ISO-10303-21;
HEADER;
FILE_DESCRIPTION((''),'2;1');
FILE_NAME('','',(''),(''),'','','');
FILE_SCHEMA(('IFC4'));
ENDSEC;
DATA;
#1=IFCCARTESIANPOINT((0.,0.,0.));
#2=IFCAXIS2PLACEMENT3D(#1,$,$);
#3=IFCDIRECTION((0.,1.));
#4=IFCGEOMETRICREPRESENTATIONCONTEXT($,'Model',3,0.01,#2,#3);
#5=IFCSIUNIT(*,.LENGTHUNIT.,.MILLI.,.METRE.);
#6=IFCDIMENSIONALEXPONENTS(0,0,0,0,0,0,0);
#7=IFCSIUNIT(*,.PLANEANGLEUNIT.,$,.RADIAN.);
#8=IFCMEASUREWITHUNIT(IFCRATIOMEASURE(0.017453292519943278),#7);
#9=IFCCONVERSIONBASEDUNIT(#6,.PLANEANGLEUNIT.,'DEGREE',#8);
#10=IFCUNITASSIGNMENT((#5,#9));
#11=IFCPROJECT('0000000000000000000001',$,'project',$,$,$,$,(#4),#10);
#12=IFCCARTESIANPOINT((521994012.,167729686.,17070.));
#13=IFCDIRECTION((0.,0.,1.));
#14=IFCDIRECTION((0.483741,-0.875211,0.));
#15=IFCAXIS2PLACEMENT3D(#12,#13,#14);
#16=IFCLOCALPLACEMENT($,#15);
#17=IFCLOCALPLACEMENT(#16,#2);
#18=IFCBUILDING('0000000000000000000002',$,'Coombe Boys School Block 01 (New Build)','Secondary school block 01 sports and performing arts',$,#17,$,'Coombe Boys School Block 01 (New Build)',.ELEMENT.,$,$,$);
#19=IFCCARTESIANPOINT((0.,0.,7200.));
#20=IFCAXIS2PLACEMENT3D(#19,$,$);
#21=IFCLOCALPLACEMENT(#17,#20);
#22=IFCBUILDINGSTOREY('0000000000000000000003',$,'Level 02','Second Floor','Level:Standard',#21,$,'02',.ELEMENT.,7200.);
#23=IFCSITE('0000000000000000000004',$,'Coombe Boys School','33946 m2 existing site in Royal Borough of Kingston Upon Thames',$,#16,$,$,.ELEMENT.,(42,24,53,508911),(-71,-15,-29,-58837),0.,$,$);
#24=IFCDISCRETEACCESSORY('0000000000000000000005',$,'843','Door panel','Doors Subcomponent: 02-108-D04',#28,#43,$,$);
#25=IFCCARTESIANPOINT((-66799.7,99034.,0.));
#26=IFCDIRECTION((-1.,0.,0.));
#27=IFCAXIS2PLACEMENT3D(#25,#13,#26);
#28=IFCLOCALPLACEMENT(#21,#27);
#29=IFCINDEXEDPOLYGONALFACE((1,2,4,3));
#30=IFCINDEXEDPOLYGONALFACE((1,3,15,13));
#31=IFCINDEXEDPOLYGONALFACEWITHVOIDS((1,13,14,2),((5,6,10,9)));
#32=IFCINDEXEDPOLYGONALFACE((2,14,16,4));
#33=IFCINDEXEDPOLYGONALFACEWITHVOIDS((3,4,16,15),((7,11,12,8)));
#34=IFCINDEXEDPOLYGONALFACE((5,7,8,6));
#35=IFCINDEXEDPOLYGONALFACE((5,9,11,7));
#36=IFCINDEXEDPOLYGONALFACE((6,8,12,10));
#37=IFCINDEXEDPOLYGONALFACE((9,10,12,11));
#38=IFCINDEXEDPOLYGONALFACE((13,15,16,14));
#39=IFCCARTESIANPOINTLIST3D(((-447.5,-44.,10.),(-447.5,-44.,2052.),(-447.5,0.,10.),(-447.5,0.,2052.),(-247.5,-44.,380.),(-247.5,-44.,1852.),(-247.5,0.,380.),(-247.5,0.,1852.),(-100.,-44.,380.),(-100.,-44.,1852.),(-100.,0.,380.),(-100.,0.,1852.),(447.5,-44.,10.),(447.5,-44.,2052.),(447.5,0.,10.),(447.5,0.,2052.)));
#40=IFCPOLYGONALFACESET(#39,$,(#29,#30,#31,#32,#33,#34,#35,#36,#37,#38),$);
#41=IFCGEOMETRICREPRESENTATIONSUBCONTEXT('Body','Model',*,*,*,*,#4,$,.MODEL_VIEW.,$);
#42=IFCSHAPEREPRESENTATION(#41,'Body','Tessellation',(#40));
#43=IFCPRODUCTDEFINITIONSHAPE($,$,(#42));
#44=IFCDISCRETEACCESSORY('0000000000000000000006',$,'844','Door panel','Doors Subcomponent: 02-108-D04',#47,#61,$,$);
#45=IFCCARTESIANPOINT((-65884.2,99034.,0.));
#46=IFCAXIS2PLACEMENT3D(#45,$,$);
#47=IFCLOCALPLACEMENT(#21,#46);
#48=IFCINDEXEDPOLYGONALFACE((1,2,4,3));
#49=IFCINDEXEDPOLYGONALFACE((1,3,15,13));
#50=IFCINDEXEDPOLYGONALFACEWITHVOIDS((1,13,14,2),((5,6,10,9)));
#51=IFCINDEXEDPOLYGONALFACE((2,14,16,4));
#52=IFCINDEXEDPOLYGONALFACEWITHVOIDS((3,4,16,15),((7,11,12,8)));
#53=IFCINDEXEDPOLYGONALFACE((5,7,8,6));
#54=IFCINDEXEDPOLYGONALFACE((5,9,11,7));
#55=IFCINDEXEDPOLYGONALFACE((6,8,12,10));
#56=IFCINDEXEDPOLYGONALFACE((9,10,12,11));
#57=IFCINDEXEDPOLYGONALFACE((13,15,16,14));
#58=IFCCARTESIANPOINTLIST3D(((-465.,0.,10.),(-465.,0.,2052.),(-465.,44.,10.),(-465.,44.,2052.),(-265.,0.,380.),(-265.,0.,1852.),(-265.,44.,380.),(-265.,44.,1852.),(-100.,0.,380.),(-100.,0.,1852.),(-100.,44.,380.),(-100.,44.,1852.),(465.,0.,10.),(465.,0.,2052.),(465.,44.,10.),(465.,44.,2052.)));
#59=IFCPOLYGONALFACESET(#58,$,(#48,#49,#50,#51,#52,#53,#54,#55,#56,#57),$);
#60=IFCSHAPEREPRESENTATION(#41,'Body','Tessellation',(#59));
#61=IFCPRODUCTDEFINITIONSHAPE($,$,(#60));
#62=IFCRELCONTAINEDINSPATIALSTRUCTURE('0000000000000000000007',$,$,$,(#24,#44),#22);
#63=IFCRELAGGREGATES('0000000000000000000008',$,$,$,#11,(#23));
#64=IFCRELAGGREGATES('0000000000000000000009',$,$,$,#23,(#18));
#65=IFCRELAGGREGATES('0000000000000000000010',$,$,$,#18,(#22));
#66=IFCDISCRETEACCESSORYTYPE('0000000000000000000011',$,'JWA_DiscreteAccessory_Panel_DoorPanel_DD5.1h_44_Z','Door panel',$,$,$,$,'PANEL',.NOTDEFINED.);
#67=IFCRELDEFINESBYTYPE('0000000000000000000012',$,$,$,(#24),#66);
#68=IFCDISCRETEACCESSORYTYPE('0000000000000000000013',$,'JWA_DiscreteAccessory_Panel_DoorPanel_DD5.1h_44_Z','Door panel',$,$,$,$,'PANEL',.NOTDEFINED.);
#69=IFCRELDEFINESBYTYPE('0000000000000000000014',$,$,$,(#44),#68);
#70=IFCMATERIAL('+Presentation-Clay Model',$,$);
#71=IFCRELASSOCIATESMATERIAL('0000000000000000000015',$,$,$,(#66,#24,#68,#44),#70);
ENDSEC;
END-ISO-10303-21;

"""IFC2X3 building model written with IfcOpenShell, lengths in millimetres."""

from ifc_helpers import new_model, entity, si_unit, converted_unit, direction, frame, origin, place, context, subcontext, project, spatial, polyline, outline, extrude, source, transform, mapped, material, type_object, type_shapes, element, save


model = new_model("IFC2X3")

# Units and contexts
model_context = context("Model", 3, precision=0.01, world=origin(), true_north=direction((0.0, 1.0)))
body_context = subcontext(model_context, "Body", "Model", "MODEL_VIEW")
ifc_project = project(units=[si_unit("LENGTHUNIT", "METRE", prefix="MILLI"), converted_unit("PLANEANGLEUNIT", "DEGREE", entity("IfcRatioMeasure", 0.017453292519943278), si_unit("PLANEANGLEUNIT", "RADIAN"), dimensions=[0, 0, 0, 0, 0, 0, 0])], contexts=[model_context])

# Site, building, storey
site_placement = place(None, frame((521994012.0, 167729686.0, 17070.0), z_axis=(0.0, 0.0, 1.0), x_axis=(0.483741, -0.875211, 0.0)))
site = spatial("IfcSite", under=ifc_project, at=site_placement, Name="Coombe Boys School", Description="33946 m2 existing site in Royal Borough of Kingston Upon Thames", CompositionType="ELEMENT", RefLatitude=(42, 24, 53, 508911), RefLongitude=(-71, -15, -29, -58837), RefElevation=0.0)
building_placement = place(site_placement, origin())
building = spatial("IfcBuilding", under=site, at=building_placement, Name="Coombe Boys School Block 01 (New Build)", Description="Secondary school block 01 sports and performing arts", LongName="Coombe Boys School Block 01 (New Build)", CompositionType="ELEMENT")
storey_placement = place(building_placement, frame((0.0, 0.0, 7200.0)))
storey = spatial("IfcBuildingStorey", under=building, at=storey_placement, Name="Level 02", Description="Second Floor", ObjectType="Level:Standard", LongName="02", CompositionType="ELEMENT", Elevation=7200.0)

# Discrete accessories
ifc_material_1 = material(Name="+Presentation-Clay Model")
discrete_accessory_type_1 = type_object("IfcDiscreteAccessoryType", Name="JWA_DiscreteAccessory_Panel_DoorPanel_DD5.1h_44_Z", Description="Door panel", ElementType="PANEL", material=ifc_material_1)
shared_shape_1 = source(origin(), body_context, "Body", "SweptSolid", [
    extrude(outline(polyline([(-1021.0, -447.5), (1021.0, -447.5), (1021.0, 447.5), (-1021.0, 447.5), (-1021.0, -447.5)]), holes=[polyline([(-821.0, 100.0), (-821.0, 247.5), (651.0, 247.5), (651.0, 100.0), (-821.0, 100.0)])]), frame((0.0, -44.0, 1031.0), z_axis=(0.0, 1.0, 0.0), x_axis=(0.0, 0.0, -1.0)), (0.0, 0.0, 1.0), 44.0),
])
type_shapes(discrete_accessory_type_1, [shared_shape_1])
discrete_accessory_1_placement = place(storey_placement, frame((-66799.7, 99034.0, 0.0), z_axis=(0.0, 0.0, 1.0), x_axis=(-1.0, 0.0, 0.0)))
element("IfcDiscreteAccessory", 1, at=discrete_accessory_1_placement, inside=storey, type_object=discrete_accessory_type_1, material=ifc_material_1, Name="843", Description="Door panel", ObjectType="Doors Subcomponent: 02-108-D04", context=body_context, shape_type="MappedRepresentation", body=[
    mapped(shared_shape_1, transform((0.0, 0.0, 0.0), scale=1.0)),
])
discrete_accessory_type_2 = type_object("IfcDiscreteAccessoryType", Name="JWA_DiscreteAccessory_Panel_DoorPanel_DD5.1h_44_Z", Description="Door panel", ElementType="PANEL", material=ifc_material_1)
shared_shape_2 = source(origin(), body_context, "Body", "SweptSolid", [
    extrude(outline(polyline([(-1021.0, -465.0), (1021.0, -465.0), (1021.0, 465.0), (-1021.0, 465.0), (-1021.0, -465.0)]), holes=[polyline([(-821.0, 100.0), (-821.0, 265.0), (651.0, 265.0), (651.0, 100.0), (-821.0, 100.0)])]), frame((0.0, 0.0, 1031.0), z_axis=(0.0, 1.0, 0.0), x_axis=(0.0, 0.0, -1.0)), (0.0, 0.0, 1.0), 44.0),
])
type_shapes(discrete_accessory_type_2, [shared_shape_2])
discrete_accessory_2_placement = place(storey_placement, frame((-65884.2, 99034.0, 0.0)))
element("IfcDiscreteAccessory", 2, at=discrete_accessory_2_placement, inside=storey, type_object=discrete_accessory_type_2, material=ifc_material_1, Name="844", Description="Door panel", ObjectType="Doors Subcomponent: 02-108-D04", context=body_context, shape_type="MappedRepresentation", body=[
    mapped(shared_shape_2, transform((0.0, 0.0, 0.0), scale=1.0)),
])

save(model, "model.ifc")
